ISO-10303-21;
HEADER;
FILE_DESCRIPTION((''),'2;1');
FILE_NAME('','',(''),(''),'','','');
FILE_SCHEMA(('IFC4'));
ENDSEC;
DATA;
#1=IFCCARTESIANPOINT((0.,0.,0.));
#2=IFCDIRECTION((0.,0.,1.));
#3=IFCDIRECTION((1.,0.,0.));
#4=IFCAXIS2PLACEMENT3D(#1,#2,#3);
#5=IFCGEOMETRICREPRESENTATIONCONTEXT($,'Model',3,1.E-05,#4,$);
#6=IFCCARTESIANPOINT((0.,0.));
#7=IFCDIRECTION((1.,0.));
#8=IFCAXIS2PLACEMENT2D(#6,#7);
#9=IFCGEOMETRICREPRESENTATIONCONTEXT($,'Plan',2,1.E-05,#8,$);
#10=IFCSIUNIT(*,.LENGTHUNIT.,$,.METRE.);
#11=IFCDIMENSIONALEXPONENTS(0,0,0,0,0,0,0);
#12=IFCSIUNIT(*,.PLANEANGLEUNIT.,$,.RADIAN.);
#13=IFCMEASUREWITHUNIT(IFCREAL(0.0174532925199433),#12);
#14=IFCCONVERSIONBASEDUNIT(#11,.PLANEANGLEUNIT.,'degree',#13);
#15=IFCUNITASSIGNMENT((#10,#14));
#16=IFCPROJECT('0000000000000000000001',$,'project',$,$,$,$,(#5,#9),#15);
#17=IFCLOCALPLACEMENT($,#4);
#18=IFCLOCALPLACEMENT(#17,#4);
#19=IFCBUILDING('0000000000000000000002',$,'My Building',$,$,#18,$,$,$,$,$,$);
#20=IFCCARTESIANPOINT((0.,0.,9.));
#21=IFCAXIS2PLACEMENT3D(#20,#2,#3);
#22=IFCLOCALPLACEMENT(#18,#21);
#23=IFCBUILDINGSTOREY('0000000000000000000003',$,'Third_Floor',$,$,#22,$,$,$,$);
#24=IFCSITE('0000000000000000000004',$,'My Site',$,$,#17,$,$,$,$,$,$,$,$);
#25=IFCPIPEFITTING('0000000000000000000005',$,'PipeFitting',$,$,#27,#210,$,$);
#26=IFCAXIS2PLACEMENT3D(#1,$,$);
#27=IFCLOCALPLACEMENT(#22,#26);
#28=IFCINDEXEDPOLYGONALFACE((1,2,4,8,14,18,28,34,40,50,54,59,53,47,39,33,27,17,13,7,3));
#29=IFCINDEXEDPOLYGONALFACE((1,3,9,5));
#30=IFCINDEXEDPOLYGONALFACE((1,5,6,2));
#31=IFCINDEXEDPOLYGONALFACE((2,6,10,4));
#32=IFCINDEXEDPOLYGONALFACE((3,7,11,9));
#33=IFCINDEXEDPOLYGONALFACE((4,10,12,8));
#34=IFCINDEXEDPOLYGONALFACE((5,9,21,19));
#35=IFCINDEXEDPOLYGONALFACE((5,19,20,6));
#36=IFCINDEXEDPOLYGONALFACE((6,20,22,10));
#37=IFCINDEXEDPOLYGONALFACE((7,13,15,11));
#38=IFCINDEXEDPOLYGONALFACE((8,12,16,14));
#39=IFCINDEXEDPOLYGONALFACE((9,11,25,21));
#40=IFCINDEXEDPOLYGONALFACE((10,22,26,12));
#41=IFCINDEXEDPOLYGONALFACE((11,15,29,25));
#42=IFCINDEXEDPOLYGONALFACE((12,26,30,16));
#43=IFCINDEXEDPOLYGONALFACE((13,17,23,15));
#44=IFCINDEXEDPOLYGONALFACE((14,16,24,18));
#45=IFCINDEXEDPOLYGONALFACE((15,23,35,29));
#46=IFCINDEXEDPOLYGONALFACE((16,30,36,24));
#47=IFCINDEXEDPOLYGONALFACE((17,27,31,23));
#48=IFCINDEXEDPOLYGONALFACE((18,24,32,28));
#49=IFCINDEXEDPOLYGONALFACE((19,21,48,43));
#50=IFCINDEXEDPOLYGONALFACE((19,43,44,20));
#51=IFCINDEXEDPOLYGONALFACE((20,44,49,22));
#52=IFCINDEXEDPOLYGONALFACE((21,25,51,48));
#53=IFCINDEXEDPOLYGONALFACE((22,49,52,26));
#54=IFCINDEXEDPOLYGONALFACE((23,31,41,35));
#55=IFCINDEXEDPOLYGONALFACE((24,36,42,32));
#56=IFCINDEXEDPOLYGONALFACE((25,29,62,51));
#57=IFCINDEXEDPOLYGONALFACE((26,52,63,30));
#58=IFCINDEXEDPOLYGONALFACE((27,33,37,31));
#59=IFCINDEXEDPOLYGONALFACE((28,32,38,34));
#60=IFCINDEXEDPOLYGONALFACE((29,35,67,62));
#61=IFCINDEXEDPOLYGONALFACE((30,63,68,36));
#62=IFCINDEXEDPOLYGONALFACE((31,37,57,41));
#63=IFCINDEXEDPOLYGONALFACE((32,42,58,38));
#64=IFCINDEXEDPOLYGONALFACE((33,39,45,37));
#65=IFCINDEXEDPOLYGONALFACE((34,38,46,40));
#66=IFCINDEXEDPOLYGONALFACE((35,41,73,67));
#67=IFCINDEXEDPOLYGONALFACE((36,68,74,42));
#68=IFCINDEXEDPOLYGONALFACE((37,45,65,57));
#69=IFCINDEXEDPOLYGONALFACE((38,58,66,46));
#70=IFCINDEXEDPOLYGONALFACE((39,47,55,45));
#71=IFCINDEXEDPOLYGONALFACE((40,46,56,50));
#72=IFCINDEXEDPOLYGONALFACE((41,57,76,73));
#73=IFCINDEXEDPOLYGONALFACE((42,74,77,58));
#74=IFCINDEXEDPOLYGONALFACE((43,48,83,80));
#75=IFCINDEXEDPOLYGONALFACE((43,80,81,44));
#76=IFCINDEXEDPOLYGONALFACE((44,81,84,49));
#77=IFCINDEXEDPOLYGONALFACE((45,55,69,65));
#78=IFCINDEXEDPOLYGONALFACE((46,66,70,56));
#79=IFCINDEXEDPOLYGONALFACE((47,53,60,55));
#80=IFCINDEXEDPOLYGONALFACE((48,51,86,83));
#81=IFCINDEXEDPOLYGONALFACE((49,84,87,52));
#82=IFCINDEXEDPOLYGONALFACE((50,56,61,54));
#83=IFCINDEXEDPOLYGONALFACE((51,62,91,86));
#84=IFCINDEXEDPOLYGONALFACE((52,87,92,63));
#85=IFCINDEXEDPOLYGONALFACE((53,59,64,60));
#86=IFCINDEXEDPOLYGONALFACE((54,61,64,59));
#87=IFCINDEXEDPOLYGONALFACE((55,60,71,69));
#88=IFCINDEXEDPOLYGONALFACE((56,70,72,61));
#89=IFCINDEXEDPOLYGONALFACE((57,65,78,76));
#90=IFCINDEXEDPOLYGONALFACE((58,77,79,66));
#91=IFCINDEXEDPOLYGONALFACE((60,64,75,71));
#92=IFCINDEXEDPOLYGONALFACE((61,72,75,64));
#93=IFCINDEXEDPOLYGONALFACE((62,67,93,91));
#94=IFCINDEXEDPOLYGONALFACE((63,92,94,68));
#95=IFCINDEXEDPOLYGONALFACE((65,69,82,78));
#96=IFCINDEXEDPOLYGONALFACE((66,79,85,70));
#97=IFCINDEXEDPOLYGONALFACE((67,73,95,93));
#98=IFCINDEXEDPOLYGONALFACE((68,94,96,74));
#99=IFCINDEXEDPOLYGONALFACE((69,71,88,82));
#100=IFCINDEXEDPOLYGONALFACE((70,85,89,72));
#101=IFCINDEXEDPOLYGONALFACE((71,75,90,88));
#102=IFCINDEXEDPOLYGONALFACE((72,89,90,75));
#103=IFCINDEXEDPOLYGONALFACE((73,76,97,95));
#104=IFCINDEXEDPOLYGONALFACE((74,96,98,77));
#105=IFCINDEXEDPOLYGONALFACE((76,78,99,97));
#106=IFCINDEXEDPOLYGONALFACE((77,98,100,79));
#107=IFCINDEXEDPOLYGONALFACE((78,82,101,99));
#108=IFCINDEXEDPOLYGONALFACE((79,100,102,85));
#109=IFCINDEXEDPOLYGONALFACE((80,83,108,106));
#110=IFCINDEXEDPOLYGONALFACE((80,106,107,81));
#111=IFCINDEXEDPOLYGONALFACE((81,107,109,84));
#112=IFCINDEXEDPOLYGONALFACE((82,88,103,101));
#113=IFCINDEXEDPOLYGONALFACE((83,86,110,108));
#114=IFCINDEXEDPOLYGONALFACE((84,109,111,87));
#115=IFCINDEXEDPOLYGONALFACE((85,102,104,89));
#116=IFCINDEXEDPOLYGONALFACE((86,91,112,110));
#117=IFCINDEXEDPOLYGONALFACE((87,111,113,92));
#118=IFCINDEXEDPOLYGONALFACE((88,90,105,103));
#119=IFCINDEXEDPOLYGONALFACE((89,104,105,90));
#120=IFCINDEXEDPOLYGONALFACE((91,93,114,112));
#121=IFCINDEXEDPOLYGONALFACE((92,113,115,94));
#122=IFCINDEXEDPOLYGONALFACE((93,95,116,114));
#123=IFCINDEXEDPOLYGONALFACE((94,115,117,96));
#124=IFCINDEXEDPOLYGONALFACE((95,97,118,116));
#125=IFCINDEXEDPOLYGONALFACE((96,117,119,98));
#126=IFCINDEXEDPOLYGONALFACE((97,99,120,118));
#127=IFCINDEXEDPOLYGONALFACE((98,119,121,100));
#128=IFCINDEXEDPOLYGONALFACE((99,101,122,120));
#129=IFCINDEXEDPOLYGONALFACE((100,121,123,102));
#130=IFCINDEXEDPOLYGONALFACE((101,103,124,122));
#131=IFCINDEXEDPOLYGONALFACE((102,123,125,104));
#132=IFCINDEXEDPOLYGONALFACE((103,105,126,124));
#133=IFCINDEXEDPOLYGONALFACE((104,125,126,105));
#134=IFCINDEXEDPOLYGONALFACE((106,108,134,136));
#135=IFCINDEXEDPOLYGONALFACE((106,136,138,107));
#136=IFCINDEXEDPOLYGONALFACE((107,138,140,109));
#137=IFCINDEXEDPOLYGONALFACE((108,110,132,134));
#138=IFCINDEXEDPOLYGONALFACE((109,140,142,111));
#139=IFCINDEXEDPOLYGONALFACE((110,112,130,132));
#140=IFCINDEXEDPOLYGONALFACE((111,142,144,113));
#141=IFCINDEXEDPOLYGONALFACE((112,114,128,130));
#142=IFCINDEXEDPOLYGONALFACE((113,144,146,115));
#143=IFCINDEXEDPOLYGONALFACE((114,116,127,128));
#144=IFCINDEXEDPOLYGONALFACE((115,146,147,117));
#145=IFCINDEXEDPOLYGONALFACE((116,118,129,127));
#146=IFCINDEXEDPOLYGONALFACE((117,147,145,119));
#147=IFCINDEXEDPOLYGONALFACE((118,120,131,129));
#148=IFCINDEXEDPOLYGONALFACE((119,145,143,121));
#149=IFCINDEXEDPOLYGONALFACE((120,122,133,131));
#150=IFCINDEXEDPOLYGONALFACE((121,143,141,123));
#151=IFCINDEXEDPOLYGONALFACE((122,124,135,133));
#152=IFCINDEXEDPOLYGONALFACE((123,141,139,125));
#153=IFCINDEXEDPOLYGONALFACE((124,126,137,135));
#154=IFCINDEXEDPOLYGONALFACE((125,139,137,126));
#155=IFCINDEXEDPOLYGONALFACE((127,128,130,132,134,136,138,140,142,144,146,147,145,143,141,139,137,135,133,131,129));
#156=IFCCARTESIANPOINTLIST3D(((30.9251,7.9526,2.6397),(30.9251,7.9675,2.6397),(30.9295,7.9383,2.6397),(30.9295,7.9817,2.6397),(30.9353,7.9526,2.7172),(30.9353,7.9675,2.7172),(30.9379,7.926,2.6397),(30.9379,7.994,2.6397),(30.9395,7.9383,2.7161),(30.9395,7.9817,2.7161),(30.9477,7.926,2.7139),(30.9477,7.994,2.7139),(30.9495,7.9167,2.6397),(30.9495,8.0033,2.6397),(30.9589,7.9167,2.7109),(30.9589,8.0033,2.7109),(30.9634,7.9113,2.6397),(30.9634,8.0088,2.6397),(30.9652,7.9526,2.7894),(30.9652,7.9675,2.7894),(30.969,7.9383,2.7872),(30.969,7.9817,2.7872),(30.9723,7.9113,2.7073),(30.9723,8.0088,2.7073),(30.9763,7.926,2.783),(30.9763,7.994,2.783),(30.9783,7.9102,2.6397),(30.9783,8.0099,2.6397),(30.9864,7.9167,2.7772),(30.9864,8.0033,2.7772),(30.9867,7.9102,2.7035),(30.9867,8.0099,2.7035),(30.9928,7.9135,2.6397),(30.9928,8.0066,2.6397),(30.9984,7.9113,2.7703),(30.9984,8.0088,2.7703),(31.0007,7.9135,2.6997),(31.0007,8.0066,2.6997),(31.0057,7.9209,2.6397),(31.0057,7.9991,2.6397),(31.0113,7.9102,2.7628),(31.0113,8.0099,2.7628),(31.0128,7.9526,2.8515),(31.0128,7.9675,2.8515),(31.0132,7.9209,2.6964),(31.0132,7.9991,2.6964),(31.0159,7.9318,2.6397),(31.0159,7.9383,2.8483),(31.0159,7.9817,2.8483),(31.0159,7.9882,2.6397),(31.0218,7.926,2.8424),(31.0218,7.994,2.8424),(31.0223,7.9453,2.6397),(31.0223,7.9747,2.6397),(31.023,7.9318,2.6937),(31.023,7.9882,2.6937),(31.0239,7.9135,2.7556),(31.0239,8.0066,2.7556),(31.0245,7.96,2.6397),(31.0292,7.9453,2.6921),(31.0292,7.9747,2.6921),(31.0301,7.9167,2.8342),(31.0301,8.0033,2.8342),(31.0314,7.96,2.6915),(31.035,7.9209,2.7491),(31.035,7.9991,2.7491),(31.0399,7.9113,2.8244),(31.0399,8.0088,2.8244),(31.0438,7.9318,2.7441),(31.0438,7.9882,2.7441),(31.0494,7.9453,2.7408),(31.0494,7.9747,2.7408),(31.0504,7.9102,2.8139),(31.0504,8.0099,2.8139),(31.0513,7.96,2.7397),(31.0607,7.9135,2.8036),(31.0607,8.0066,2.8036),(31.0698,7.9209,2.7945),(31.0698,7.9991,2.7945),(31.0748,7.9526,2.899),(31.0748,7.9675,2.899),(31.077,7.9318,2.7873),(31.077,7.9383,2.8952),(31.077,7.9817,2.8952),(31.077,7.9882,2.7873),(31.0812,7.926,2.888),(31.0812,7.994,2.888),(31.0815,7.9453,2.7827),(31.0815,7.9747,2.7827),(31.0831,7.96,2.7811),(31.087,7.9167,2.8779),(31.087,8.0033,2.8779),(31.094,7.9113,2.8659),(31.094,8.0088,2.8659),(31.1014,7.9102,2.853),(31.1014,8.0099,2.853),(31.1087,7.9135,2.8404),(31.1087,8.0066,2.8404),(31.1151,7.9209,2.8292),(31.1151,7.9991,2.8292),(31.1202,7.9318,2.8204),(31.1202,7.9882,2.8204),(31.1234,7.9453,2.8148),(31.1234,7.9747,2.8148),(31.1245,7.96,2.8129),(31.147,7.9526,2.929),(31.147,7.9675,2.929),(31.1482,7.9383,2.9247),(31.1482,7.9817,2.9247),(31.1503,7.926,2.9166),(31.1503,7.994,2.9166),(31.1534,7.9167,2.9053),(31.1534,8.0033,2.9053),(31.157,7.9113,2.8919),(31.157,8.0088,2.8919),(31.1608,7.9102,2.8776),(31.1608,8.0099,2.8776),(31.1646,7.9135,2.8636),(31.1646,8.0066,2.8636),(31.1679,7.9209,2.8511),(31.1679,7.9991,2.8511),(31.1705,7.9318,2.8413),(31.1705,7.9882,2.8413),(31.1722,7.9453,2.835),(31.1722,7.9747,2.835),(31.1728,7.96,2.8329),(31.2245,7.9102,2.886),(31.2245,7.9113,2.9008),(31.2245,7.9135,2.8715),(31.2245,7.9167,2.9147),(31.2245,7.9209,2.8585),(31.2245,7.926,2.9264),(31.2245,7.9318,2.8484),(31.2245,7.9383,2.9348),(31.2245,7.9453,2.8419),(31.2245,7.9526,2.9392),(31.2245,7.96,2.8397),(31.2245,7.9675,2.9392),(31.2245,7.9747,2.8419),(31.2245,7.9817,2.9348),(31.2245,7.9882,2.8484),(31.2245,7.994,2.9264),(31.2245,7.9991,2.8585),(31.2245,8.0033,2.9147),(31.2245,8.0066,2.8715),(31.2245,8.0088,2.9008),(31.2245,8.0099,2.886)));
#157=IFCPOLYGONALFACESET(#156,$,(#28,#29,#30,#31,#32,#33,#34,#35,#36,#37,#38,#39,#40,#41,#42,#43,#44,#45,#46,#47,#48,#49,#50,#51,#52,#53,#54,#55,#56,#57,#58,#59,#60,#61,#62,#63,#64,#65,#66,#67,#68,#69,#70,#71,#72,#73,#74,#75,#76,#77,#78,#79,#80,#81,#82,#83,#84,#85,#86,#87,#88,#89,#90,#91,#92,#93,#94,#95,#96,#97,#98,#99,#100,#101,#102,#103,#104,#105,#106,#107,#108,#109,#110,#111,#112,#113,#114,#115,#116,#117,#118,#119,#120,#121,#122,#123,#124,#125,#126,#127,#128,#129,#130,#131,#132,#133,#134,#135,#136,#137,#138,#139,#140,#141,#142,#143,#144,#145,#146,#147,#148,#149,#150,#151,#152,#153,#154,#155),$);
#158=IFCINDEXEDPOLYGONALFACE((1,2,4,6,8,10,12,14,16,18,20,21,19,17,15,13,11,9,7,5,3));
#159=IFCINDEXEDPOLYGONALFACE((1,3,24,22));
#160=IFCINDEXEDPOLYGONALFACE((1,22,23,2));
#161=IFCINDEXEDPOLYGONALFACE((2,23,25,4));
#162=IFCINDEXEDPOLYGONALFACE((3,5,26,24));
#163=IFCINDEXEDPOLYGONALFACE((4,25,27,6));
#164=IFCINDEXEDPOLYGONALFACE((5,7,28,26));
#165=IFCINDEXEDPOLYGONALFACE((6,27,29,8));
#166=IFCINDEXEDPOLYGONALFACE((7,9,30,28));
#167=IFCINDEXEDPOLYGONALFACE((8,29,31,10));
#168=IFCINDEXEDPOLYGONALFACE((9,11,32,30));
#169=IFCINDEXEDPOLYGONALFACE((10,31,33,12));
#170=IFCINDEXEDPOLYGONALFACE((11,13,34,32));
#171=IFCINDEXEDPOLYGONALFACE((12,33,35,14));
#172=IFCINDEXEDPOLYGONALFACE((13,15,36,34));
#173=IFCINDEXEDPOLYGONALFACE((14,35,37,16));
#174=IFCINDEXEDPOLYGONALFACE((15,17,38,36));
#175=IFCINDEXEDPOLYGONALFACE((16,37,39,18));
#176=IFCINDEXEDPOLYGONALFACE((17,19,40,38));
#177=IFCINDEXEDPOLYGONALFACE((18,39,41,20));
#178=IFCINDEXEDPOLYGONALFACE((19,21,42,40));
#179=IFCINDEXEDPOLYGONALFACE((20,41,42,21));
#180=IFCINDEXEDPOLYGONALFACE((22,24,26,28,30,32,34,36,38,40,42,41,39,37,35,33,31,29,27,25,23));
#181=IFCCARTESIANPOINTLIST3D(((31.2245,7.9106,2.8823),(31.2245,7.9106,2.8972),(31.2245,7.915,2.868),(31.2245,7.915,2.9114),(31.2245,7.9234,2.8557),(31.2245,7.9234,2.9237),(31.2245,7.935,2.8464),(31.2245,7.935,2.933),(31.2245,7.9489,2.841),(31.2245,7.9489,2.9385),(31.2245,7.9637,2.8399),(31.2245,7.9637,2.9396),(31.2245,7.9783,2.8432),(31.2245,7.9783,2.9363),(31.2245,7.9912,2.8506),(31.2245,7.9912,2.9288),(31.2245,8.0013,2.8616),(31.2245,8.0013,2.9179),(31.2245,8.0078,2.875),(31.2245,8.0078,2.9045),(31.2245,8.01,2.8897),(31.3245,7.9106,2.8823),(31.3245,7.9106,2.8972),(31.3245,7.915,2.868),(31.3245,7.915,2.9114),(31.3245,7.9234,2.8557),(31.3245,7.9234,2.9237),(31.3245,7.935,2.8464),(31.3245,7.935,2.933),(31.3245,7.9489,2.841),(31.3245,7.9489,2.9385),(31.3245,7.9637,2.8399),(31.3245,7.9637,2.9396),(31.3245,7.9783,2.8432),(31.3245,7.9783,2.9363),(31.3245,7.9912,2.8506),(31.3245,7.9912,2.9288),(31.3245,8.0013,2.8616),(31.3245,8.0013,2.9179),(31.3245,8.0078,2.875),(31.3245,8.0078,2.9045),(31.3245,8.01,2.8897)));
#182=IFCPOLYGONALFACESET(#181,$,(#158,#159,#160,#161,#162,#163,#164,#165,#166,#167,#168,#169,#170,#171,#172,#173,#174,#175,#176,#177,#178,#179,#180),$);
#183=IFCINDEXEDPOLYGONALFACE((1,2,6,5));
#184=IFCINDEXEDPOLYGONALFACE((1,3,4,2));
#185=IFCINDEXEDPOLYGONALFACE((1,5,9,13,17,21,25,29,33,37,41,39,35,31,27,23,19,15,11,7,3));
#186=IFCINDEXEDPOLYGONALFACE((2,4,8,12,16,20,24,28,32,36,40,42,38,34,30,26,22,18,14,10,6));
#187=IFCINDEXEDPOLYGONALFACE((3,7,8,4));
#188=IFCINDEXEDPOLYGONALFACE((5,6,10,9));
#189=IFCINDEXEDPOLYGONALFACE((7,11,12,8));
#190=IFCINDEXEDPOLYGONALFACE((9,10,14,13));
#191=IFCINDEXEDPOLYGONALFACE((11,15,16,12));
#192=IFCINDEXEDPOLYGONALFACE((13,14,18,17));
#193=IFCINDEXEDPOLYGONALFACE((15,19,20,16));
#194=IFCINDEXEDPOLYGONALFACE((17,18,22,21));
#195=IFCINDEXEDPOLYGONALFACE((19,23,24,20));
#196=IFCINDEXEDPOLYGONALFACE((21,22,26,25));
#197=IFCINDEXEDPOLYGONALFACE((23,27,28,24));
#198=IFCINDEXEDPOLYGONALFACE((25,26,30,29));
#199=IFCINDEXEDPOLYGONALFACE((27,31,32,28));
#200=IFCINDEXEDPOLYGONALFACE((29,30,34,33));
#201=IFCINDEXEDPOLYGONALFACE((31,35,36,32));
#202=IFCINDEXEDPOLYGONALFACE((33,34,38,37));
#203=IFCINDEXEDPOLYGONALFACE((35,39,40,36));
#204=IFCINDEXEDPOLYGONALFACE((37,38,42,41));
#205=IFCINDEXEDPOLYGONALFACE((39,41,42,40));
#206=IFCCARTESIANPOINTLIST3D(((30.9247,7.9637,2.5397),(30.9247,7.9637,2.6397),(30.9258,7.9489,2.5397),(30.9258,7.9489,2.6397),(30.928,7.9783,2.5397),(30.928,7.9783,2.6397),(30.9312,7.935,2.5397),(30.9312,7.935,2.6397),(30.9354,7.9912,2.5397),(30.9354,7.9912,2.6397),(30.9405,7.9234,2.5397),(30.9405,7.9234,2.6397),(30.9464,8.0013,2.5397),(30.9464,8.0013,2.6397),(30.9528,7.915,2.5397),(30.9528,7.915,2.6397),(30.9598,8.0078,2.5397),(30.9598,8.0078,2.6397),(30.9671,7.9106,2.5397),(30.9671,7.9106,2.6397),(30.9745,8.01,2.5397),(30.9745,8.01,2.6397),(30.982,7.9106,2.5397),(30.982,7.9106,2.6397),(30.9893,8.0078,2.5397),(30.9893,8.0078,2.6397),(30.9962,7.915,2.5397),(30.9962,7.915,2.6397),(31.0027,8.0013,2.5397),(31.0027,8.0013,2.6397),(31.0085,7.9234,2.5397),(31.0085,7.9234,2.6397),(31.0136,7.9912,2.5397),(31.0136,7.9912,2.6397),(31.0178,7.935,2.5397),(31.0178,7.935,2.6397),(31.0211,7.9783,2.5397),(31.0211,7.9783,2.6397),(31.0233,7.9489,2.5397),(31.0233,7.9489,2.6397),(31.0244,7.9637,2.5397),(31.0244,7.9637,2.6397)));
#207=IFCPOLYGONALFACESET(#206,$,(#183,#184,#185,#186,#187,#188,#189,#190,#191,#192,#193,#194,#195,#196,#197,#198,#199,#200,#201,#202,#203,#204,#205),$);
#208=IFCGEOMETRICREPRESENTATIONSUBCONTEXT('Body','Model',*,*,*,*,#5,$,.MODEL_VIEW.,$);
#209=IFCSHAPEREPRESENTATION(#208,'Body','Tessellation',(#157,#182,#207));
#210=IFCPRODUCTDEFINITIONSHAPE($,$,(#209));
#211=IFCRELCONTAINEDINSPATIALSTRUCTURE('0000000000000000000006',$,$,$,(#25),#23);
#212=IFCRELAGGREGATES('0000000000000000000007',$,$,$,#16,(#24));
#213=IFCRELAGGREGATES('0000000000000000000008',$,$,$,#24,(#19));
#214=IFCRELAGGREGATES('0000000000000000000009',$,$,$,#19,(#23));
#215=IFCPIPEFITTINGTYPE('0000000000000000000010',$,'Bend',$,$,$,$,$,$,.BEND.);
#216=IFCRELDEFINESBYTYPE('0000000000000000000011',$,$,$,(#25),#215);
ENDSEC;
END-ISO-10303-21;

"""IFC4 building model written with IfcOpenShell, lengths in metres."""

from ifc_helpers import new_model, entity, si_unit, converted_unit, frame, origin_with_axes, origin_2d_with_axis, place, context, subcontext, project, spatial, circle, extrude, source, transform, mapped, type_object, type_shapes, element, save


model = new_model("IFC4")

# Units and contexts
model_context = context("Model", 3, precision=1e-05, world=origin_with_axes())
plan_context = context("Plan", 2, precision=1e-05, world=origin_2d_with_axis())
body_context_1 = subcontext(model_context, "Body", "Model", "MODEL_VIEW")
ifc_project = project(units=[si_unit("LENGTHUNIT", "METRE"), converted_unit("PLANEANGLEUNIT", "degree", entity("IfcReal", 0.0174532925199433), si_unit("PLANEANGLEUNIT", "RADIAN"), dimensions=[0, 0, 0, 0, 0, 0, 0])], contexts=[model_context, plan_context])

# Site, building, storey
site_placement = place(None, origin_with_axes())
site = spatial("IfcSite", under=ifc_project, at=site_placement, Name="My Site")
building_placement = place(site_placement, origin_with_axes())
building = spatial("IfcBuilding", under=site, at=building_placement, Name="My Building")
storey_placement = place(building_placement, frame((0.0, 0.0, 9.0), z_axis=(0.0, 0.0, 1.0), x_axis=(1.0, 0.0, 0.0)))
storey = spatial("IfcBuildingStorey", under=building, at=storey_placement, Name="Third_Floor")

# Pipe fitting
pipe_fitting_type = type_object("IfcPipeFittingType", Name="Bend", PredefinedType="BEND")
shared_shape_1 = source(origin_with_axes(), body_context_1, "Body", "SolidModel", [
    entity("IfcSweptDiskSolid", entity("IfcIndexedPolyCurve", entity("IfcCartesianPointList3D", [[0.0, 0.0, -0.1], [0.0, -0.0732, -0.2768], [0.0, -0.25, -0.35]]), [entity("IfcArcIndex", [1, 2, 3])]), 0.05),
    extrude(circle(Radius=0.05), origin_with_axes(), (0.0, 0.0, -1.0), 0.1),
    extrude(circle(Radius=0.05), frame((0.0, -0.25, -0.35), z_axis=(0.0, -1.0, 0.0), x_axis=(1.0, 0.0, 0.0)), (0.0, 0.0, 1.0), 0.1),
])
type_shapes(pipe_fitting_type, [shared_shape_1])
for number, where, z_axis, x_axis, name in (
    (1, (31.3245, 7.96, 2.8897), (1.0, 0.000001, 0.0), (-0.000001, 1.0, 0.0), "PipeFitting"),
):
    element("IfcPipeFitting", number, at=place(storey_placement, frame(where, z_axis=z_axis, x_axis=x_axis)), inside=storey, type_object=pipe_fitting_type, Name=name, context=body_context_1, shape_type="MappedRepresentation", body=[
        mapped(shared_shape_1, transform((0.0, 0.0, 0.0), x_axis=(1.0, 0.0, 0.0), y_axis=(0.0, 1.0, 0.0), z_axis=(0.0, 0.0, 1.0), scale=1.0)),
    ])

save(model, "model.ifc")
